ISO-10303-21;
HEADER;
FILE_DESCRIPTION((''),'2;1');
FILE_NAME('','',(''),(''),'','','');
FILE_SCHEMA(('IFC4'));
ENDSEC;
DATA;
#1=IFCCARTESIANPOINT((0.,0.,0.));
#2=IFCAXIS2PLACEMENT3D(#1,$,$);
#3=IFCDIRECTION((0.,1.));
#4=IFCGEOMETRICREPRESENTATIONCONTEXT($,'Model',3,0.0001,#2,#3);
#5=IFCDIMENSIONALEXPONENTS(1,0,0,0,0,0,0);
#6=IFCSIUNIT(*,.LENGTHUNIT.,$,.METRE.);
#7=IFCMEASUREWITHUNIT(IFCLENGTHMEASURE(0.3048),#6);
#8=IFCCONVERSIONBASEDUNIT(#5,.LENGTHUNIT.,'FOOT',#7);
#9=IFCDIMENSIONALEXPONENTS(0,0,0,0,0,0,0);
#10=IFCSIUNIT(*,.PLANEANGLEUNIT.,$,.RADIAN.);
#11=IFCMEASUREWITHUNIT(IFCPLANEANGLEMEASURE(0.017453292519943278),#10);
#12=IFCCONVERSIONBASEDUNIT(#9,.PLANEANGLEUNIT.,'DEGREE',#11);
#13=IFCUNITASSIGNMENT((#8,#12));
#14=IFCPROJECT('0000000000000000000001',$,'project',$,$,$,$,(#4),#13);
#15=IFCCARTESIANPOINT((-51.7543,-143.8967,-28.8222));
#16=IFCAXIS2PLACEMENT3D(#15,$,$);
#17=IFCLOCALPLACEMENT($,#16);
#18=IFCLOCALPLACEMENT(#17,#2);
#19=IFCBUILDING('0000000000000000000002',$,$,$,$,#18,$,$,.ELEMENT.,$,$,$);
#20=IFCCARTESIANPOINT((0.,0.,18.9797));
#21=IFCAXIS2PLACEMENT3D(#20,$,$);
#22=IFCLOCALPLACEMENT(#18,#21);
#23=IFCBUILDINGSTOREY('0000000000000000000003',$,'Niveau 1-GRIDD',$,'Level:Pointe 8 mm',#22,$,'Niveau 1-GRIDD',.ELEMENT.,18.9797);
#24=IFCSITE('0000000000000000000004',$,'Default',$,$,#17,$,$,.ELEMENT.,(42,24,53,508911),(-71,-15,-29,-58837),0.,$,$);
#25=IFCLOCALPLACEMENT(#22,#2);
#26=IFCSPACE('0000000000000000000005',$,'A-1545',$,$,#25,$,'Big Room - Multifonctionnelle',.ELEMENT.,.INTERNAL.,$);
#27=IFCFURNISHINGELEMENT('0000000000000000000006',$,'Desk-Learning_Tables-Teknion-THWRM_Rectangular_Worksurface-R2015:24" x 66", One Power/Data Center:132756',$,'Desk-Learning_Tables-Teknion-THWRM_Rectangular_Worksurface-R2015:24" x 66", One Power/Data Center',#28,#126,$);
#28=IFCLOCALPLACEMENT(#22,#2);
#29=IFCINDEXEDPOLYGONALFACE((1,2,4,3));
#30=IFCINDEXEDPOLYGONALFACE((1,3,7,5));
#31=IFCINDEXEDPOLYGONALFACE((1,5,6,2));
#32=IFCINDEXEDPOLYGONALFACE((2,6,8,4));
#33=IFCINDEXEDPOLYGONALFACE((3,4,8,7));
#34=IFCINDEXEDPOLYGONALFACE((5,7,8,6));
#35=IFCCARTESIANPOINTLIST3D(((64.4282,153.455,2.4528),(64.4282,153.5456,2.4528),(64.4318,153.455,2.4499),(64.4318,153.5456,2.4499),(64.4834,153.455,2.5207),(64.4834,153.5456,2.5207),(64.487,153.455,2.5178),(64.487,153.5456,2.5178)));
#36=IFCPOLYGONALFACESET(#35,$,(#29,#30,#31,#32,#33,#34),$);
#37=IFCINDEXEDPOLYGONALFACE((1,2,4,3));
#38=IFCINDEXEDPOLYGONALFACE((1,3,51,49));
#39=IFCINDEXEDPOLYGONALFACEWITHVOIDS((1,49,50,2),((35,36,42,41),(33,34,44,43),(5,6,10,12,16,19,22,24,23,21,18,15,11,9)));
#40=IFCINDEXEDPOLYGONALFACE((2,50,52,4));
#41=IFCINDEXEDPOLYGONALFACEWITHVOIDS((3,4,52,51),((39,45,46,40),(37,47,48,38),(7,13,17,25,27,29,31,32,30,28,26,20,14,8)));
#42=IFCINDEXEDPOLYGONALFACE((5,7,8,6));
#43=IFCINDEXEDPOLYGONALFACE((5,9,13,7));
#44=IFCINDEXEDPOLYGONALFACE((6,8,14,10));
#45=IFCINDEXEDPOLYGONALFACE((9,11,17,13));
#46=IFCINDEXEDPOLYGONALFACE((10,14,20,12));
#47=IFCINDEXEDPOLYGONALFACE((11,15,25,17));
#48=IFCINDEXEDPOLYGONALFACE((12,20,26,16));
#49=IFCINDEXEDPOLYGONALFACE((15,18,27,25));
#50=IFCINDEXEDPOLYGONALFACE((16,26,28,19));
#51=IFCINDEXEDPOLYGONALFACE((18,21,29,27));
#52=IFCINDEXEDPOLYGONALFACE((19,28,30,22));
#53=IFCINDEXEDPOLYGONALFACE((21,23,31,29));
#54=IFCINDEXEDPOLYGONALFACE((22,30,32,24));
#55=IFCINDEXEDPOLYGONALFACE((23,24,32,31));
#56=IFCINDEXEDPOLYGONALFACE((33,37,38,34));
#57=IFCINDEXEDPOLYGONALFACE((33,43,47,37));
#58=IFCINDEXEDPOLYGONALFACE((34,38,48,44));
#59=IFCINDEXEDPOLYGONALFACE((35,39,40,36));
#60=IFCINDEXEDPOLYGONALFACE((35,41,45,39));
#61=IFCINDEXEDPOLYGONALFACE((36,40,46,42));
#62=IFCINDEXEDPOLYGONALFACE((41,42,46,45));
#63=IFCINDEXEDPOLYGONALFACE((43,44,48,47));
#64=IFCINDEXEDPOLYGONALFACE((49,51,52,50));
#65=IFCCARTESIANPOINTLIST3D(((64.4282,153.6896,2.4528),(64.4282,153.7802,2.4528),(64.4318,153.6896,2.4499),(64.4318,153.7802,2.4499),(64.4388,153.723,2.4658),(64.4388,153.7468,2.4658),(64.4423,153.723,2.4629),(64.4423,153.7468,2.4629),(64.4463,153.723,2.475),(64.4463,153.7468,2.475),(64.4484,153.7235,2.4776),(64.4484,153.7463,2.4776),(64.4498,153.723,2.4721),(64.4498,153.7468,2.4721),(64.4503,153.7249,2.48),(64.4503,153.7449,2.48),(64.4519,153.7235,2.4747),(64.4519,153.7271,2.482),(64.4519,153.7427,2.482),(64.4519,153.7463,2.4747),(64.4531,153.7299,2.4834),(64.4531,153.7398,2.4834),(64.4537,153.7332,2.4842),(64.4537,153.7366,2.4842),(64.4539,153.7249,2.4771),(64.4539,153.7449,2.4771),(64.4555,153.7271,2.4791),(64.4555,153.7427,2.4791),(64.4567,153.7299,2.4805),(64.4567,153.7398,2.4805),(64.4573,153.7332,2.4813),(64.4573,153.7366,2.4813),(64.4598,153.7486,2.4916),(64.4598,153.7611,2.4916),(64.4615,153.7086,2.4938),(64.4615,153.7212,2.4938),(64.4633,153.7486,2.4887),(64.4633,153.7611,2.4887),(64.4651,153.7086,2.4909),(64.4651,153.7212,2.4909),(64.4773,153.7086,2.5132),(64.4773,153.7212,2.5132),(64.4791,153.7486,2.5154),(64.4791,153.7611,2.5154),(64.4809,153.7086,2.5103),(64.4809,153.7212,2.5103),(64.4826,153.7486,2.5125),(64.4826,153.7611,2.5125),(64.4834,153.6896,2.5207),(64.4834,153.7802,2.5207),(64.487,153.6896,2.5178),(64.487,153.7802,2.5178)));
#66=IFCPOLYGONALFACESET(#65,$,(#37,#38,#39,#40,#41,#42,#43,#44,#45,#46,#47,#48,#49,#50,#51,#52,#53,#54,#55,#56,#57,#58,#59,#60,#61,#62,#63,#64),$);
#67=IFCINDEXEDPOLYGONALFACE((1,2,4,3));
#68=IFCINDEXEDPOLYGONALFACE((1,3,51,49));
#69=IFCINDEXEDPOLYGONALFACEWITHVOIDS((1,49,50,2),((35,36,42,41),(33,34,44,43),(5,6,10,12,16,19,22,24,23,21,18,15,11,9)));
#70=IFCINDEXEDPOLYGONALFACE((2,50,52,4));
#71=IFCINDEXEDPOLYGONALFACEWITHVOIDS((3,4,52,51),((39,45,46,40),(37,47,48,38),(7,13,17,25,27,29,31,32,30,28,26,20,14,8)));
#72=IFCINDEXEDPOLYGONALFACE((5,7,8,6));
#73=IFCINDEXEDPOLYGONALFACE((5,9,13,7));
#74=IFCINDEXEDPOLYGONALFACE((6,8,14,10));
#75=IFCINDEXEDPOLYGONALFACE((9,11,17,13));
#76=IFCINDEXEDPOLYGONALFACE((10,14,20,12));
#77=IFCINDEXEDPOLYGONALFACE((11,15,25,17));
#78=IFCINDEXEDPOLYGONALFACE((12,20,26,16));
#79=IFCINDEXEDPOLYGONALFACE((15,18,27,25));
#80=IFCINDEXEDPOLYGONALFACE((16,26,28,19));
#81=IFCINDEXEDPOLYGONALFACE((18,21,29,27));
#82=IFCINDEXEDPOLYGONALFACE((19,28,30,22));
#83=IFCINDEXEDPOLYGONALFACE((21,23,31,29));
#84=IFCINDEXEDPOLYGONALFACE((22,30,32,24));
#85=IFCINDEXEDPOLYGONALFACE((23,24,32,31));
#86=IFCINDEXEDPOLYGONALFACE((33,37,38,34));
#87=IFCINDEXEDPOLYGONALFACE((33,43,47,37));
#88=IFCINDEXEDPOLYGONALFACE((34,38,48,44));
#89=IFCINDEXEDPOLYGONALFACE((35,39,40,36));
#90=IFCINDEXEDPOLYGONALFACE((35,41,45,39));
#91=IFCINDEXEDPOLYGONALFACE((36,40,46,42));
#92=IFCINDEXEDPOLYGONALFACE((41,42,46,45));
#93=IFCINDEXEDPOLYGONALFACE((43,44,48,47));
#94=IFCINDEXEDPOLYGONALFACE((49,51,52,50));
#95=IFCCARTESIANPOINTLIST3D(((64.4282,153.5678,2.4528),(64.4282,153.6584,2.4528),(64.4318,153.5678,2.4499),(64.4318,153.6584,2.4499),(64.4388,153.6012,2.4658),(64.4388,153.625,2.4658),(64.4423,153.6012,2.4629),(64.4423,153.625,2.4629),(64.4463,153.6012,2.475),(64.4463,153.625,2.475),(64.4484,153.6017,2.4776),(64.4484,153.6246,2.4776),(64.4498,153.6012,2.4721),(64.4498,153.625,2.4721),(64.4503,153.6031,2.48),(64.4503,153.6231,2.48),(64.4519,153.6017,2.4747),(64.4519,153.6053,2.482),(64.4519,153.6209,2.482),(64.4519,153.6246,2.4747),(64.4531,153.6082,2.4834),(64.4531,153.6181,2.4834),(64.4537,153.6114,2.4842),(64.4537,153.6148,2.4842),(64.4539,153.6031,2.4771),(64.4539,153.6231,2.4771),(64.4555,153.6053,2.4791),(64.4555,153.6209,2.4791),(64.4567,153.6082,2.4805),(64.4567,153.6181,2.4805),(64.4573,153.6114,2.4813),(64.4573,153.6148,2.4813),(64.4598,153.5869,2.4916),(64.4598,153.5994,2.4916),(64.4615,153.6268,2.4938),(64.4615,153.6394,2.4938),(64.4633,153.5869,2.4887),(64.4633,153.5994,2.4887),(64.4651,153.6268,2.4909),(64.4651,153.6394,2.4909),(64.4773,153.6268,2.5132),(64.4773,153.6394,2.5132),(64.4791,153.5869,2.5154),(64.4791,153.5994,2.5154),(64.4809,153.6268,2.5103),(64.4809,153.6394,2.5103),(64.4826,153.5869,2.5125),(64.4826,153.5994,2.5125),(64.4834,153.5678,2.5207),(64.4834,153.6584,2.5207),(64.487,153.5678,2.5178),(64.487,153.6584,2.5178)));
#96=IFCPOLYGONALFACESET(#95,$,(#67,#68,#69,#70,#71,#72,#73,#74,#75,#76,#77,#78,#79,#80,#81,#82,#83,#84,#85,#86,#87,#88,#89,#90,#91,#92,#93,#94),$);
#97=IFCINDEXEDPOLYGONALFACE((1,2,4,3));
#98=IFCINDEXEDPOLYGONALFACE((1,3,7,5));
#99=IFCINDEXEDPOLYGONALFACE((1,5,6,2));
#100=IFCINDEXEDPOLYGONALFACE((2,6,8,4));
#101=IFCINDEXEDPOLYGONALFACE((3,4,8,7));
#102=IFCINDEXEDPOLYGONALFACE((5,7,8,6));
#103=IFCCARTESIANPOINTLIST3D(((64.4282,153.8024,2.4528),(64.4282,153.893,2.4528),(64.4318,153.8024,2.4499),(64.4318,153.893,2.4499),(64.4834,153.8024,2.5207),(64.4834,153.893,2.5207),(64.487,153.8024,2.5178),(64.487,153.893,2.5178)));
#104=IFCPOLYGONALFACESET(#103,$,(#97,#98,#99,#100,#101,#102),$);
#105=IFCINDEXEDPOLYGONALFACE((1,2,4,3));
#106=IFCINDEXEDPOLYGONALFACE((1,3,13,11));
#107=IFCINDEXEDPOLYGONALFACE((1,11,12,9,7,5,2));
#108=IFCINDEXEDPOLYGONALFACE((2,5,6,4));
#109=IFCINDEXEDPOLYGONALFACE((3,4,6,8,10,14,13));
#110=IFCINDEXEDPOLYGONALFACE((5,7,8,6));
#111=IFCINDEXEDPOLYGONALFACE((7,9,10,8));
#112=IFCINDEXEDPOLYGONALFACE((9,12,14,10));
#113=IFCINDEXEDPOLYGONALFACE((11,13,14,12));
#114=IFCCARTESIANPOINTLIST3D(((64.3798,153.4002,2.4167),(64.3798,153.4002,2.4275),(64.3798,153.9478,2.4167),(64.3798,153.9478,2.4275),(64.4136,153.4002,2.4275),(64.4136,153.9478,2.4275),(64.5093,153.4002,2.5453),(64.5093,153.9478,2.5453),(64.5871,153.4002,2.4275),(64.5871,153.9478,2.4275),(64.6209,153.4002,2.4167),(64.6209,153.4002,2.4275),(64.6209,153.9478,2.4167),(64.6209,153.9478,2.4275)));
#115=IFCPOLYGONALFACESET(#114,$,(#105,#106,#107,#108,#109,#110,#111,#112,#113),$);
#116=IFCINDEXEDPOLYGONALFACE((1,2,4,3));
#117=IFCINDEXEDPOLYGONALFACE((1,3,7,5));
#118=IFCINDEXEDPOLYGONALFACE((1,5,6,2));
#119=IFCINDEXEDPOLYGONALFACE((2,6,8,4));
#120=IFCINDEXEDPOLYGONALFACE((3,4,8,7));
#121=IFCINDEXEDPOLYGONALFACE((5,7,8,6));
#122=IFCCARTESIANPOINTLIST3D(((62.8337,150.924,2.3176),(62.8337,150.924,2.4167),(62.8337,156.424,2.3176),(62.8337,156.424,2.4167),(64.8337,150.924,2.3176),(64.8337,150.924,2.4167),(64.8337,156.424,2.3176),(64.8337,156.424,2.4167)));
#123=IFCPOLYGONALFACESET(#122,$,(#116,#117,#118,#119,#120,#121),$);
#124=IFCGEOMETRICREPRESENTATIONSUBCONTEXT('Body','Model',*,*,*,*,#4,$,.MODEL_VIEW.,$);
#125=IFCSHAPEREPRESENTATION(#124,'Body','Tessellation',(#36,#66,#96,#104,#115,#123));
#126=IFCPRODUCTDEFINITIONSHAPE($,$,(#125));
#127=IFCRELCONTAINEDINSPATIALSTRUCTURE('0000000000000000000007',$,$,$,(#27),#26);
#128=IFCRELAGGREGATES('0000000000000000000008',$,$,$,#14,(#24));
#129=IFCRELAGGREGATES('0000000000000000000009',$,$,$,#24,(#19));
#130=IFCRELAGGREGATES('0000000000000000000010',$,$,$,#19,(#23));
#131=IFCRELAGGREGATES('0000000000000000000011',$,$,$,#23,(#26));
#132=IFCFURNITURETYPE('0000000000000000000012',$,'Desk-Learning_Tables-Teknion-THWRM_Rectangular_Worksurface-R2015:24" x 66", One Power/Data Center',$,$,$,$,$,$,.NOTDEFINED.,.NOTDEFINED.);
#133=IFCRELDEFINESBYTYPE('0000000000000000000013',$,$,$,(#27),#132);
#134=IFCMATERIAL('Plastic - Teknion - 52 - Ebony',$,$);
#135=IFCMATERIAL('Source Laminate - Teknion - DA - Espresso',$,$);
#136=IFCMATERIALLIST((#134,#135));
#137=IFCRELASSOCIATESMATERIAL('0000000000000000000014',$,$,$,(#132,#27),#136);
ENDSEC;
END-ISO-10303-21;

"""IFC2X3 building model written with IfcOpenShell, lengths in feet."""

from ifc_helpers import new_model, entity, si_unit, converted_unit, direction, frame, frame_2d, origin, place, context, subcontext, project, spatial, polyline, circle_curve, parameter, trimmed, segment, composite_curve, rectangle, outline, extrude, source, transform, mapped, material, material_list, type_object, type_shapes, element, save


model = new_model("IFC2X3")

# Units and contexts
model_context = context("Model", 3, precision=0.0001, world=origin(), true_north=direction((0.0, 1.0)))
body_context = subcontext(model_context, "Body", "Model", "MODEL_VIEW")
ifc_project = project(units=[converted_unit("LENGTHUNIT", "FOOT", entity("IfcLengthMeasure", 0.3048), si_unit("LENGTHUNIT", "METRE"), dimensions=[1, 0, 0, 0, 0, 0, 0]), converted_unit("PLANEANGLEUNIT", "DEGREE", entity("IfcPlaneAngleMeasure", 0.017453292519943278), si_unit("PLANEANGLEUNIT", "RADIAN"), dimensions=[0, 0, 0, 0, 0, 0, 0])], contexts=[model_context])

# Site, building, storey
site_placement = place(None, frame((-51.7543, -143.8967, -28.8222)))
site = spatial("IfcSite", under=ifc_project, at=site_placement, Name="Default", CompositionType="ELEMENT", RefLatitude=(42, 24, 53, 508911), RefLongitude=(-71, -15, -29, -58837), RefElevation=0.0)
building_placement = place(site_placement, origin())
building = spatial("IfcBuilding", under=site, at=building_placement, CompositionType="ELEMENT")
storey_placement = place(building_placement, frame((0.0, 0.0, 18.9797)))
storey = spatial("IfcBuildingStorey", under=building, at=storey_placement, Name="Niveau 1-GRIDD", ObjectType="Level:Pointe 8 mm", LongName="Niveau 1-GRIDD", CompositionType="ELEMENT", Elevation=18.9797)

# Shared definitions
space_placement = place(storey_placement, origin())
space = spatial("IfcSpace", under=storey, at=space_placement, Name="A-1545", LongName="Big Room - Multifonctionnelle", CompositionType="ELEMENT", InteriorOrExteriorSpace="INTERNAL")

# Furnishing element
ifc_material_1 = material(Name="Plastic - Teknion - 52 - Ebony")
ifc_material_2 = material(Name="Source Laminate - Teknion - DA - Espresso")
ifc_material_list_1 = material_list([ifc_material_1, ifc_material_2])
furniture_type_1 = type_object("IfcFurnitureType", Name="Desk-Learning_Tables-Teknion-THWRM_Rectangular_Worksurface-R2015:24\" x 66\", One Power/Data Center", AssemblyPlace="NOTDEFINED", material=ifc_material_list_1)
shared_shape_1 = source(origin(), body_context, "Body", "SweptSolid", [
    extrude(rectangle(XDim=0.0875, YDim=0.0046, at=frame_2d((0.0, 0.0), x_axis=(0.0, 1.0))), frame((0.1284, 0.6239, 2.4853), z_axis=(1.0, 0.0, 0.0), x_axis=(0.0, 0.776046, -0.630676)), (0.0, 0.0, 1.0), 0.0906),
    extrude(outline(polyline([(-0.0453, -0.0438), (0.0453, -0.0438), (0.0453, 0.0438), (-0.0453, 0.0438), (-0.0453, -0.0438)]), holes=[polyline([(-0.0262, -0.0063), (-0.0137, -0.0063), (-0.0137, -0.0369), (-0.0262, -0.0369), (-0.0262, -0.0063)]), polyline([(0.0137, -0.0341), (0.0137, -0.0091), (0.0262, -0.0091), (0.0262, -0.0341), (0.0137, -0.0341)]), composite_curve([segment(polyline([(-0.0119, 0.027), (0.0119, 0.027)]), True, "CONTINUOUS"), segment(polyline([(0.0119, 0.027), (0.0119, 0.0151)]), True, "CONTINUOUS"), segment(trimmed(circle_curve(frame_2d((0.0, 0.0151), x_axis=(0.0, -1.0)), 0.0119), [parameter(270.0)], [parameter(90.0)], True, "PARAMETER"), False, "CONTINUOUS"), segment(polyline([(-0.0119, 0.0151), (-0.0119, 0.027)]), True, "CONTINUOUS")], self_intersect=False)]), frame((-0.0609, 0.6221, 2.4867), z_axis=(0.0, 0.776046, -0.630676), x_axis=(1.0, 0.0, 0.0)), (0.0, 0.0, 1.0), 0.0046),
    extrude(outline(polyline([(-0.0438, -0.0453), (0.0438, -0.0453), (0.0438, 0.0453), (-0.0438, 0.0453), (-0.0438, -0.0453)]), holes=[polyline([(-0.0063, -0.0262), (-0.0369, -0.0262), (-0.0369, -0.0137), (-0.0063, -0.0137), (-0.0063, -0.0262)]), polyline([(-0.0341, 0.0137), (-0.0341, 0.0262), (-0.0091, 0.0262), (-0.0091, 0.0137), (-0.0341, 0.0137)]), composite_curve([segment(polyline([(0.027, -0.0119), (0.0151, -0.0119)]), True, "CONTINUOUS"), segment(trimmed(circle_curve(frame_2d((0.0151, 0.0), x_axis=(-1.0, 0.0)), 0.0119), [parameter(270.0)], [parameter(90.0)], True, "PARAMETER"), False, "CONTINUOUS"), segment(polyline([(0.0151, 0.0119), (0.027, 0.0119)]), True, "CONTINUOUS"), segment(polyline([(0.027, 0.0119), (0.027, -0.0119)]), True, "CONTINUOUS")], self_intersect=False)]), frame((0.0609, 0.6221, 2.4867), z_axis=(0.0, 0.776046, -0.630676), x_axis=(0.0, -0.630676, -0.776046)), (0.0, 0.0, 1.0), 0.0046),
    extrude(rectangle(XDim=0.0875, YDim=0.0046, at=frame_2d((0.0, 0.0), x_axis=(0.0, 1.0))), frame((-0.219, 0.6239, 2.4853), z_axis=(1.0, 0.0, 0.0), x_axis=(0.0, 0.776046, -0.630676)), (0.0, 0.0, 1.0), 0.0906),
    extrude(outline(polyline([(-0.0586, -0.0638), (0.0826, -0.0638), (0.0371, 0.0811), (0.0557, 0.1093), (0.0467, 0.1152), (-0.0862, -0.086), (-0.0772, -0.092), (-0.0586, -0.0638)])), frame((-0.2738, 0.6679, 2.4412), z_axis=(1.0, 0.0, 0.0), x_axis=(0.0, -0.551103, 0.834437)), (0.0, 0.0, 1.0), 0.5475),
    extrude(rectangle(XDim=5.5, YDim=2.0, at=frame_2d((0.0, 0.0), x_axis=(1.0, 0.0))), frame((0.0, 0.0, 2.3176), z_axis=(0.0, 0.0, 1.0), x_axis=(-1.0, 0.0, 0.0)), (0.0, 0.0, 1.0), 0.0991),
])
type_shapes(furniture_type_1, [shared_shape_1])
for number, where, z_axis, x_axis, name in (
    (1, (63.8337, 153.674, 0.0), (0.0, 0.0, 1.0), (0.0, -1.0, 0.0), "Desk-Learning_Tables-Teknion-THWRM_Rectangular_Worksurface-R2015:24\" x 66\", One Power/Data Center:132756"),
):
    element("IfcFurnishingElement", number, at=place(space_placement, frame(where, z_axis=z_axis, x_axis=x_axis)), inside=space, type_object=furniture_type_1, material=ifc_material_list_1, Name=name, ObjectType="Desk-Learning_Tables-Teknion-THWRM_Rectangular_Worksurface-R2015:24\" x 66\", One Power/Data Center", context=body_context, shape_type="MappedRepresentation", body=[
        mapped(shared_shape_1, transform((0.0, 0.0, 0.0), scale=1.0)),
    ])

save(model, "model.ifc")
